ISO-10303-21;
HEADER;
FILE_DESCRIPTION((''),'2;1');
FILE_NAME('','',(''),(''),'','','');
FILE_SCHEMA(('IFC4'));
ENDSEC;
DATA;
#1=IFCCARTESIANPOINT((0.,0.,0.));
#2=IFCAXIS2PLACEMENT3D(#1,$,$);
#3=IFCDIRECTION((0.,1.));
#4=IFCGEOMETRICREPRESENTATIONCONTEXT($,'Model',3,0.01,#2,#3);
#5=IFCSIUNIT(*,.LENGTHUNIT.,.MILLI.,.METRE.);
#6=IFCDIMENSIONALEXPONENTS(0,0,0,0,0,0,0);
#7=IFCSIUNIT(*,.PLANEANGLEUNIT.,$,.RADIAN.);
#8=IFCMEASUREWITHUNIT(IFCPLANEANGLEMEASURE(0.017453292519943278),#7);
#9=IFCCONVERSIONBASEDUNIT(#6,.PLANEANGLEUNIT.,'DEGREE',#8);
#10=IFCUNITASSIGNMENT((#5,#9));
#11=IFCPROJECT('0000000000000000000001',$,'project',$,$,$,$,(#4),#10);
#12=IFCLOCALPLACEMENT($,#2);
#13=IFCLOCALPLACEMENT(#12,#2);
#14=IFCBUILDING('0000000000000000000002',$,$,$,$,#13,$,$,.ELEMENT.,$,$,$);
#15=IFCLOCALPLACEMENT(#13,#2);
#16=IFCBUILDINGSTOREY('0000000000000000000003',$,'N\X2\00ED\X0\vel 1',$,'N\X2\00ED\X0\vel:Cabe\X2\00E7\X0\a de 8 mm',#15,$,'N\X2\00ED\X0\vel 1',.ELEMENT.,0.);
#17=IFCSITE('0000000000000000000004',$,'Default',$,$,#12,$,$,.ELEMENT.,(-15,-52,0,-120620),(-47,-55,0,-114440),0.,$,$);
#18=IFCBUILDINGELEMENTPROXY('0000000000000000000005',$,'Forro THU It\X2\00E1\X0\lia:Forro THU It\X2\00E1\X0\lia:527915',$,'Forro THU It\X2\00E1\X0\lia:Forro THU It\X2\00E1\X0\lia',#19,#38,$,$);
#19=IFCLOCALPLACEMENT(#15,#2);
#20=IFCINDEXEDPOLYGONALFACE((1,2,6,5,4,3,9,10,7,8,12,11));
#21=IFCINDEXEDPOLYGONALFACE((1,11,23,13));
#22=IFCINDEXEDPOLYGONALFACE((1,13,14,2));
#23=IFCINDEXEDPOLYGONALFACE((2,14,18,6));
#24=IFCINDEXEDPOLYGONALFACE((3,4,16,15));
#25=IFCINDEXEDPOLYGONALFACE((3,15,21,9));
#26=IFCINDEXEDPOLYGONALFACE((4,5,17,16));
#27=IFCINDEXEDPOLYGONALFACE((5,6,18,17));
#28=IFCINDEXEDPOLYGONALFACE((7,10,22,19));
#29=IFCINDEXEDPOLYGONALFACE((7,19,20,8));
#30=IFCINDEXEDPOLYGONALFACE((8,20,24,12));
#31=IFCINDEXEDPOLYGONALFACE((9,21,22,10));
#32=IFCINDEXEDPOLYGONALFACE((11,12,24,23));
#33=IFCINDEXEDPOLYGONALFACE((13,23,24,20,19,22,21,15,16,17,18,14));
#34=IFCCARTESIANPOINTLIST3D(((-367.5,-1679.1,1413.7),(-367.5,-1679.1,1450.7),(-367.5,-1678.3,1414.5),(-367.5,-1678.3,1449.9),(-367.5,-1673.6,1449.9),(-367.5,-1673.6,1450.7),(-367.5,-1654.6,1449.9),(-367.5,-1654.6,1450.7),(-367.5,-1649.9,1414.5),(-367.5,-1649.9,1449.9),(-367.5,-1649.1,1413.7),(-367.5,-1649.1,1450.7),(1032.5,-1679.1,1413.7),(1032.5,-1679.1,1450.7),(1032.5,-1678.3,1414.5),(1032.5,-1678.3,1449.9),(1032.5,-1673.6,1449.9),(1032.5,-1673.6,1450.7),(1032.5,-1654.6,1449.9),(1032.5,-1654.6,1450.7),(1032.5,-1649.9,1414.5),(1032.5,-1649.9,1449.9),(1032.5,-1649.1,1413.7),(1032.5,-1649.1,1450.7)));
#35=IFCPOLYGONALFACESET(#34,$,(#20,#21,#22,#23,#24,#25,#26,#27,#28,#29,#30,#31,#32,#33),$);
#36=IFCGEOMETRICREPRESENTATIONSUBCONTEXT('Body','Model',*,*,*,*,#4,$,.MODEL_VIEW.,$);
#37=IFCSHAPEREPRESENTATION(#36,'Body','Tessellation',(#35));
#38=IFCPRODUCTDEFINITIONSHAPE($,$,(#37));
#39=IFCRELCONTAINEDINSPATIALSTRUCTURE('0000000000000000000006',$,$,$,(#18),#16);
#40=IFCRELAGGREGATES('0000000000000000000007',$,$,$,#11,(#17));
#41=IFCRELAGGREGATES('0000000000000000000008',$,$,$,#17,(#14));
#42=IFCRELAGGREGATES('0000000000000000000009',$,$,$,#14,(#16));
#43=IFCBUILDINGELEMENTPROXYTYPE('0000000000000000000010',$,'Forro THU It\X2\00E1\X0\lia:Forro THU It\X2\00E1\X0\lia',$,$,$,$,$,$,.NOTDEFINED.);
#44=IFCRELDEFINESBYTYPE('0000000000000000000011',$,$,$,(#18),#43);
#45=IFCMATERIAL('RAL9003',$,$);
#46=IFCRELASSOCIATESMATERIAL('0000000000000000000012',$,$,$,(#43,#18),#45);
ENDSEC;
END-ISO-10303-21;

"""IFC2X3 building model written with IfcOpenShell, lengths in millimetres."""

from ifc_helpers import new_model, entity, si_unit, converted_unit, direction, frame, origin, place, context, subcontext, project, spatial, polyline, outline, extrude, source, transform, mapped, material, type_object, type_shapes, element, save


model = new_model("IFC2X3")

# Units and contexts
model_context = context("Model", 3, precision=0.01, world=origin(), true_north=direction((0.0, 1.0)))
body_context = subcontext(model_context, "Body", "Model", "MODEL_VIEW")
ifc_project = project(units=[si_unit("LENGTHUNIT", "METRE", prefix="MILLI"), converted_unit("PLANEANGLEUNIT", "DEGREE", entity("IfcPlaneAngleMeasure", 0.017453292519943278), si_unit("PLANEANGLEUNIT", "RADIAN"), dimensions=[0, 0, 0, 0, 0, 0, 0])], contexts=[model_context])

# Site, building, storey
site_placement = place(None, origin())
site = spatial("IfcSite", under=ifc_project, at=site_placement, Name="Default", CompositionType="ELEMENT", RefLatitude=(-15, -52, 0, -120620), RefLongitude=(-47, -55, 0, -114440), RefElevation=0.0)
building_placement = place(site_placement, origin())
building = spatial("IfcBuilding", under=site, at=building_placement, CompositionType="ELEMENT")
storey_placement = place(building_placement, origin())
storey = spatial("IfcBuildingStorey", under=building, at=storey_placement, Name="Nível 1", ObjectType="Nível:Cabeça de 8 mm", LongName="Nível 1", CompositionType="ELEMENT", Elevation=0.0)

# Building element proxy
ifc_material_1 = material(Name="RAL9003")
building_element_proxy_type = type_object("IfcBuildingElementProxyType", Name="Forro THU Itália:Forro THU Itália", PredefinedType="NOTDEFINED", material=ifc_material_1)
shared_shape_1 = source(origin(), body_context, "Body", "SweptSolid", [
    extrude(outline(polyline([(-12.5, -15.0), (24.5, -15.0), (24.5, 15.0), (-12.5, 15.0), (-12.5, 9.5), (-11.7, 9.5), (-11.7, 14.2), (23.7, 14.2), (23.7, -14.2), (-11.7, -14.2), (-11.7, -9.5), (-12.5, -9.5), (-12.5, -15.0)])), frame((0.0, 15.0, -12.5), z_axis=(1.0, 0.0, 0.0), x_axis=(0.0, 0.0, -1.0)), (0.0, 0.0, 1.0), 1400.0),
])
type_shapes(building_element_proxy_type, [shared_shape_1])
for number, where, name in (
    (1, (-367.5, -1679.1, 1450.7), "Forro THU Itália:Forro THU Itália:527915"),
):
    element("IfcBuildingElementProxy", number, at=place(storey_placement, frame(where)), inside=storey, type_object=building_element_proxy_type, material=ifc_material_1, Name=name, ObjectType="Forro THU Itália:Forro THU Itália", context=body_context, shape_type="MappedRepresentation", body=[
        mapped(shared_shape_1, transform((0.0, 0.0, 0.0), scale=1.0)),
    ])

save(model, "model.ifc")
